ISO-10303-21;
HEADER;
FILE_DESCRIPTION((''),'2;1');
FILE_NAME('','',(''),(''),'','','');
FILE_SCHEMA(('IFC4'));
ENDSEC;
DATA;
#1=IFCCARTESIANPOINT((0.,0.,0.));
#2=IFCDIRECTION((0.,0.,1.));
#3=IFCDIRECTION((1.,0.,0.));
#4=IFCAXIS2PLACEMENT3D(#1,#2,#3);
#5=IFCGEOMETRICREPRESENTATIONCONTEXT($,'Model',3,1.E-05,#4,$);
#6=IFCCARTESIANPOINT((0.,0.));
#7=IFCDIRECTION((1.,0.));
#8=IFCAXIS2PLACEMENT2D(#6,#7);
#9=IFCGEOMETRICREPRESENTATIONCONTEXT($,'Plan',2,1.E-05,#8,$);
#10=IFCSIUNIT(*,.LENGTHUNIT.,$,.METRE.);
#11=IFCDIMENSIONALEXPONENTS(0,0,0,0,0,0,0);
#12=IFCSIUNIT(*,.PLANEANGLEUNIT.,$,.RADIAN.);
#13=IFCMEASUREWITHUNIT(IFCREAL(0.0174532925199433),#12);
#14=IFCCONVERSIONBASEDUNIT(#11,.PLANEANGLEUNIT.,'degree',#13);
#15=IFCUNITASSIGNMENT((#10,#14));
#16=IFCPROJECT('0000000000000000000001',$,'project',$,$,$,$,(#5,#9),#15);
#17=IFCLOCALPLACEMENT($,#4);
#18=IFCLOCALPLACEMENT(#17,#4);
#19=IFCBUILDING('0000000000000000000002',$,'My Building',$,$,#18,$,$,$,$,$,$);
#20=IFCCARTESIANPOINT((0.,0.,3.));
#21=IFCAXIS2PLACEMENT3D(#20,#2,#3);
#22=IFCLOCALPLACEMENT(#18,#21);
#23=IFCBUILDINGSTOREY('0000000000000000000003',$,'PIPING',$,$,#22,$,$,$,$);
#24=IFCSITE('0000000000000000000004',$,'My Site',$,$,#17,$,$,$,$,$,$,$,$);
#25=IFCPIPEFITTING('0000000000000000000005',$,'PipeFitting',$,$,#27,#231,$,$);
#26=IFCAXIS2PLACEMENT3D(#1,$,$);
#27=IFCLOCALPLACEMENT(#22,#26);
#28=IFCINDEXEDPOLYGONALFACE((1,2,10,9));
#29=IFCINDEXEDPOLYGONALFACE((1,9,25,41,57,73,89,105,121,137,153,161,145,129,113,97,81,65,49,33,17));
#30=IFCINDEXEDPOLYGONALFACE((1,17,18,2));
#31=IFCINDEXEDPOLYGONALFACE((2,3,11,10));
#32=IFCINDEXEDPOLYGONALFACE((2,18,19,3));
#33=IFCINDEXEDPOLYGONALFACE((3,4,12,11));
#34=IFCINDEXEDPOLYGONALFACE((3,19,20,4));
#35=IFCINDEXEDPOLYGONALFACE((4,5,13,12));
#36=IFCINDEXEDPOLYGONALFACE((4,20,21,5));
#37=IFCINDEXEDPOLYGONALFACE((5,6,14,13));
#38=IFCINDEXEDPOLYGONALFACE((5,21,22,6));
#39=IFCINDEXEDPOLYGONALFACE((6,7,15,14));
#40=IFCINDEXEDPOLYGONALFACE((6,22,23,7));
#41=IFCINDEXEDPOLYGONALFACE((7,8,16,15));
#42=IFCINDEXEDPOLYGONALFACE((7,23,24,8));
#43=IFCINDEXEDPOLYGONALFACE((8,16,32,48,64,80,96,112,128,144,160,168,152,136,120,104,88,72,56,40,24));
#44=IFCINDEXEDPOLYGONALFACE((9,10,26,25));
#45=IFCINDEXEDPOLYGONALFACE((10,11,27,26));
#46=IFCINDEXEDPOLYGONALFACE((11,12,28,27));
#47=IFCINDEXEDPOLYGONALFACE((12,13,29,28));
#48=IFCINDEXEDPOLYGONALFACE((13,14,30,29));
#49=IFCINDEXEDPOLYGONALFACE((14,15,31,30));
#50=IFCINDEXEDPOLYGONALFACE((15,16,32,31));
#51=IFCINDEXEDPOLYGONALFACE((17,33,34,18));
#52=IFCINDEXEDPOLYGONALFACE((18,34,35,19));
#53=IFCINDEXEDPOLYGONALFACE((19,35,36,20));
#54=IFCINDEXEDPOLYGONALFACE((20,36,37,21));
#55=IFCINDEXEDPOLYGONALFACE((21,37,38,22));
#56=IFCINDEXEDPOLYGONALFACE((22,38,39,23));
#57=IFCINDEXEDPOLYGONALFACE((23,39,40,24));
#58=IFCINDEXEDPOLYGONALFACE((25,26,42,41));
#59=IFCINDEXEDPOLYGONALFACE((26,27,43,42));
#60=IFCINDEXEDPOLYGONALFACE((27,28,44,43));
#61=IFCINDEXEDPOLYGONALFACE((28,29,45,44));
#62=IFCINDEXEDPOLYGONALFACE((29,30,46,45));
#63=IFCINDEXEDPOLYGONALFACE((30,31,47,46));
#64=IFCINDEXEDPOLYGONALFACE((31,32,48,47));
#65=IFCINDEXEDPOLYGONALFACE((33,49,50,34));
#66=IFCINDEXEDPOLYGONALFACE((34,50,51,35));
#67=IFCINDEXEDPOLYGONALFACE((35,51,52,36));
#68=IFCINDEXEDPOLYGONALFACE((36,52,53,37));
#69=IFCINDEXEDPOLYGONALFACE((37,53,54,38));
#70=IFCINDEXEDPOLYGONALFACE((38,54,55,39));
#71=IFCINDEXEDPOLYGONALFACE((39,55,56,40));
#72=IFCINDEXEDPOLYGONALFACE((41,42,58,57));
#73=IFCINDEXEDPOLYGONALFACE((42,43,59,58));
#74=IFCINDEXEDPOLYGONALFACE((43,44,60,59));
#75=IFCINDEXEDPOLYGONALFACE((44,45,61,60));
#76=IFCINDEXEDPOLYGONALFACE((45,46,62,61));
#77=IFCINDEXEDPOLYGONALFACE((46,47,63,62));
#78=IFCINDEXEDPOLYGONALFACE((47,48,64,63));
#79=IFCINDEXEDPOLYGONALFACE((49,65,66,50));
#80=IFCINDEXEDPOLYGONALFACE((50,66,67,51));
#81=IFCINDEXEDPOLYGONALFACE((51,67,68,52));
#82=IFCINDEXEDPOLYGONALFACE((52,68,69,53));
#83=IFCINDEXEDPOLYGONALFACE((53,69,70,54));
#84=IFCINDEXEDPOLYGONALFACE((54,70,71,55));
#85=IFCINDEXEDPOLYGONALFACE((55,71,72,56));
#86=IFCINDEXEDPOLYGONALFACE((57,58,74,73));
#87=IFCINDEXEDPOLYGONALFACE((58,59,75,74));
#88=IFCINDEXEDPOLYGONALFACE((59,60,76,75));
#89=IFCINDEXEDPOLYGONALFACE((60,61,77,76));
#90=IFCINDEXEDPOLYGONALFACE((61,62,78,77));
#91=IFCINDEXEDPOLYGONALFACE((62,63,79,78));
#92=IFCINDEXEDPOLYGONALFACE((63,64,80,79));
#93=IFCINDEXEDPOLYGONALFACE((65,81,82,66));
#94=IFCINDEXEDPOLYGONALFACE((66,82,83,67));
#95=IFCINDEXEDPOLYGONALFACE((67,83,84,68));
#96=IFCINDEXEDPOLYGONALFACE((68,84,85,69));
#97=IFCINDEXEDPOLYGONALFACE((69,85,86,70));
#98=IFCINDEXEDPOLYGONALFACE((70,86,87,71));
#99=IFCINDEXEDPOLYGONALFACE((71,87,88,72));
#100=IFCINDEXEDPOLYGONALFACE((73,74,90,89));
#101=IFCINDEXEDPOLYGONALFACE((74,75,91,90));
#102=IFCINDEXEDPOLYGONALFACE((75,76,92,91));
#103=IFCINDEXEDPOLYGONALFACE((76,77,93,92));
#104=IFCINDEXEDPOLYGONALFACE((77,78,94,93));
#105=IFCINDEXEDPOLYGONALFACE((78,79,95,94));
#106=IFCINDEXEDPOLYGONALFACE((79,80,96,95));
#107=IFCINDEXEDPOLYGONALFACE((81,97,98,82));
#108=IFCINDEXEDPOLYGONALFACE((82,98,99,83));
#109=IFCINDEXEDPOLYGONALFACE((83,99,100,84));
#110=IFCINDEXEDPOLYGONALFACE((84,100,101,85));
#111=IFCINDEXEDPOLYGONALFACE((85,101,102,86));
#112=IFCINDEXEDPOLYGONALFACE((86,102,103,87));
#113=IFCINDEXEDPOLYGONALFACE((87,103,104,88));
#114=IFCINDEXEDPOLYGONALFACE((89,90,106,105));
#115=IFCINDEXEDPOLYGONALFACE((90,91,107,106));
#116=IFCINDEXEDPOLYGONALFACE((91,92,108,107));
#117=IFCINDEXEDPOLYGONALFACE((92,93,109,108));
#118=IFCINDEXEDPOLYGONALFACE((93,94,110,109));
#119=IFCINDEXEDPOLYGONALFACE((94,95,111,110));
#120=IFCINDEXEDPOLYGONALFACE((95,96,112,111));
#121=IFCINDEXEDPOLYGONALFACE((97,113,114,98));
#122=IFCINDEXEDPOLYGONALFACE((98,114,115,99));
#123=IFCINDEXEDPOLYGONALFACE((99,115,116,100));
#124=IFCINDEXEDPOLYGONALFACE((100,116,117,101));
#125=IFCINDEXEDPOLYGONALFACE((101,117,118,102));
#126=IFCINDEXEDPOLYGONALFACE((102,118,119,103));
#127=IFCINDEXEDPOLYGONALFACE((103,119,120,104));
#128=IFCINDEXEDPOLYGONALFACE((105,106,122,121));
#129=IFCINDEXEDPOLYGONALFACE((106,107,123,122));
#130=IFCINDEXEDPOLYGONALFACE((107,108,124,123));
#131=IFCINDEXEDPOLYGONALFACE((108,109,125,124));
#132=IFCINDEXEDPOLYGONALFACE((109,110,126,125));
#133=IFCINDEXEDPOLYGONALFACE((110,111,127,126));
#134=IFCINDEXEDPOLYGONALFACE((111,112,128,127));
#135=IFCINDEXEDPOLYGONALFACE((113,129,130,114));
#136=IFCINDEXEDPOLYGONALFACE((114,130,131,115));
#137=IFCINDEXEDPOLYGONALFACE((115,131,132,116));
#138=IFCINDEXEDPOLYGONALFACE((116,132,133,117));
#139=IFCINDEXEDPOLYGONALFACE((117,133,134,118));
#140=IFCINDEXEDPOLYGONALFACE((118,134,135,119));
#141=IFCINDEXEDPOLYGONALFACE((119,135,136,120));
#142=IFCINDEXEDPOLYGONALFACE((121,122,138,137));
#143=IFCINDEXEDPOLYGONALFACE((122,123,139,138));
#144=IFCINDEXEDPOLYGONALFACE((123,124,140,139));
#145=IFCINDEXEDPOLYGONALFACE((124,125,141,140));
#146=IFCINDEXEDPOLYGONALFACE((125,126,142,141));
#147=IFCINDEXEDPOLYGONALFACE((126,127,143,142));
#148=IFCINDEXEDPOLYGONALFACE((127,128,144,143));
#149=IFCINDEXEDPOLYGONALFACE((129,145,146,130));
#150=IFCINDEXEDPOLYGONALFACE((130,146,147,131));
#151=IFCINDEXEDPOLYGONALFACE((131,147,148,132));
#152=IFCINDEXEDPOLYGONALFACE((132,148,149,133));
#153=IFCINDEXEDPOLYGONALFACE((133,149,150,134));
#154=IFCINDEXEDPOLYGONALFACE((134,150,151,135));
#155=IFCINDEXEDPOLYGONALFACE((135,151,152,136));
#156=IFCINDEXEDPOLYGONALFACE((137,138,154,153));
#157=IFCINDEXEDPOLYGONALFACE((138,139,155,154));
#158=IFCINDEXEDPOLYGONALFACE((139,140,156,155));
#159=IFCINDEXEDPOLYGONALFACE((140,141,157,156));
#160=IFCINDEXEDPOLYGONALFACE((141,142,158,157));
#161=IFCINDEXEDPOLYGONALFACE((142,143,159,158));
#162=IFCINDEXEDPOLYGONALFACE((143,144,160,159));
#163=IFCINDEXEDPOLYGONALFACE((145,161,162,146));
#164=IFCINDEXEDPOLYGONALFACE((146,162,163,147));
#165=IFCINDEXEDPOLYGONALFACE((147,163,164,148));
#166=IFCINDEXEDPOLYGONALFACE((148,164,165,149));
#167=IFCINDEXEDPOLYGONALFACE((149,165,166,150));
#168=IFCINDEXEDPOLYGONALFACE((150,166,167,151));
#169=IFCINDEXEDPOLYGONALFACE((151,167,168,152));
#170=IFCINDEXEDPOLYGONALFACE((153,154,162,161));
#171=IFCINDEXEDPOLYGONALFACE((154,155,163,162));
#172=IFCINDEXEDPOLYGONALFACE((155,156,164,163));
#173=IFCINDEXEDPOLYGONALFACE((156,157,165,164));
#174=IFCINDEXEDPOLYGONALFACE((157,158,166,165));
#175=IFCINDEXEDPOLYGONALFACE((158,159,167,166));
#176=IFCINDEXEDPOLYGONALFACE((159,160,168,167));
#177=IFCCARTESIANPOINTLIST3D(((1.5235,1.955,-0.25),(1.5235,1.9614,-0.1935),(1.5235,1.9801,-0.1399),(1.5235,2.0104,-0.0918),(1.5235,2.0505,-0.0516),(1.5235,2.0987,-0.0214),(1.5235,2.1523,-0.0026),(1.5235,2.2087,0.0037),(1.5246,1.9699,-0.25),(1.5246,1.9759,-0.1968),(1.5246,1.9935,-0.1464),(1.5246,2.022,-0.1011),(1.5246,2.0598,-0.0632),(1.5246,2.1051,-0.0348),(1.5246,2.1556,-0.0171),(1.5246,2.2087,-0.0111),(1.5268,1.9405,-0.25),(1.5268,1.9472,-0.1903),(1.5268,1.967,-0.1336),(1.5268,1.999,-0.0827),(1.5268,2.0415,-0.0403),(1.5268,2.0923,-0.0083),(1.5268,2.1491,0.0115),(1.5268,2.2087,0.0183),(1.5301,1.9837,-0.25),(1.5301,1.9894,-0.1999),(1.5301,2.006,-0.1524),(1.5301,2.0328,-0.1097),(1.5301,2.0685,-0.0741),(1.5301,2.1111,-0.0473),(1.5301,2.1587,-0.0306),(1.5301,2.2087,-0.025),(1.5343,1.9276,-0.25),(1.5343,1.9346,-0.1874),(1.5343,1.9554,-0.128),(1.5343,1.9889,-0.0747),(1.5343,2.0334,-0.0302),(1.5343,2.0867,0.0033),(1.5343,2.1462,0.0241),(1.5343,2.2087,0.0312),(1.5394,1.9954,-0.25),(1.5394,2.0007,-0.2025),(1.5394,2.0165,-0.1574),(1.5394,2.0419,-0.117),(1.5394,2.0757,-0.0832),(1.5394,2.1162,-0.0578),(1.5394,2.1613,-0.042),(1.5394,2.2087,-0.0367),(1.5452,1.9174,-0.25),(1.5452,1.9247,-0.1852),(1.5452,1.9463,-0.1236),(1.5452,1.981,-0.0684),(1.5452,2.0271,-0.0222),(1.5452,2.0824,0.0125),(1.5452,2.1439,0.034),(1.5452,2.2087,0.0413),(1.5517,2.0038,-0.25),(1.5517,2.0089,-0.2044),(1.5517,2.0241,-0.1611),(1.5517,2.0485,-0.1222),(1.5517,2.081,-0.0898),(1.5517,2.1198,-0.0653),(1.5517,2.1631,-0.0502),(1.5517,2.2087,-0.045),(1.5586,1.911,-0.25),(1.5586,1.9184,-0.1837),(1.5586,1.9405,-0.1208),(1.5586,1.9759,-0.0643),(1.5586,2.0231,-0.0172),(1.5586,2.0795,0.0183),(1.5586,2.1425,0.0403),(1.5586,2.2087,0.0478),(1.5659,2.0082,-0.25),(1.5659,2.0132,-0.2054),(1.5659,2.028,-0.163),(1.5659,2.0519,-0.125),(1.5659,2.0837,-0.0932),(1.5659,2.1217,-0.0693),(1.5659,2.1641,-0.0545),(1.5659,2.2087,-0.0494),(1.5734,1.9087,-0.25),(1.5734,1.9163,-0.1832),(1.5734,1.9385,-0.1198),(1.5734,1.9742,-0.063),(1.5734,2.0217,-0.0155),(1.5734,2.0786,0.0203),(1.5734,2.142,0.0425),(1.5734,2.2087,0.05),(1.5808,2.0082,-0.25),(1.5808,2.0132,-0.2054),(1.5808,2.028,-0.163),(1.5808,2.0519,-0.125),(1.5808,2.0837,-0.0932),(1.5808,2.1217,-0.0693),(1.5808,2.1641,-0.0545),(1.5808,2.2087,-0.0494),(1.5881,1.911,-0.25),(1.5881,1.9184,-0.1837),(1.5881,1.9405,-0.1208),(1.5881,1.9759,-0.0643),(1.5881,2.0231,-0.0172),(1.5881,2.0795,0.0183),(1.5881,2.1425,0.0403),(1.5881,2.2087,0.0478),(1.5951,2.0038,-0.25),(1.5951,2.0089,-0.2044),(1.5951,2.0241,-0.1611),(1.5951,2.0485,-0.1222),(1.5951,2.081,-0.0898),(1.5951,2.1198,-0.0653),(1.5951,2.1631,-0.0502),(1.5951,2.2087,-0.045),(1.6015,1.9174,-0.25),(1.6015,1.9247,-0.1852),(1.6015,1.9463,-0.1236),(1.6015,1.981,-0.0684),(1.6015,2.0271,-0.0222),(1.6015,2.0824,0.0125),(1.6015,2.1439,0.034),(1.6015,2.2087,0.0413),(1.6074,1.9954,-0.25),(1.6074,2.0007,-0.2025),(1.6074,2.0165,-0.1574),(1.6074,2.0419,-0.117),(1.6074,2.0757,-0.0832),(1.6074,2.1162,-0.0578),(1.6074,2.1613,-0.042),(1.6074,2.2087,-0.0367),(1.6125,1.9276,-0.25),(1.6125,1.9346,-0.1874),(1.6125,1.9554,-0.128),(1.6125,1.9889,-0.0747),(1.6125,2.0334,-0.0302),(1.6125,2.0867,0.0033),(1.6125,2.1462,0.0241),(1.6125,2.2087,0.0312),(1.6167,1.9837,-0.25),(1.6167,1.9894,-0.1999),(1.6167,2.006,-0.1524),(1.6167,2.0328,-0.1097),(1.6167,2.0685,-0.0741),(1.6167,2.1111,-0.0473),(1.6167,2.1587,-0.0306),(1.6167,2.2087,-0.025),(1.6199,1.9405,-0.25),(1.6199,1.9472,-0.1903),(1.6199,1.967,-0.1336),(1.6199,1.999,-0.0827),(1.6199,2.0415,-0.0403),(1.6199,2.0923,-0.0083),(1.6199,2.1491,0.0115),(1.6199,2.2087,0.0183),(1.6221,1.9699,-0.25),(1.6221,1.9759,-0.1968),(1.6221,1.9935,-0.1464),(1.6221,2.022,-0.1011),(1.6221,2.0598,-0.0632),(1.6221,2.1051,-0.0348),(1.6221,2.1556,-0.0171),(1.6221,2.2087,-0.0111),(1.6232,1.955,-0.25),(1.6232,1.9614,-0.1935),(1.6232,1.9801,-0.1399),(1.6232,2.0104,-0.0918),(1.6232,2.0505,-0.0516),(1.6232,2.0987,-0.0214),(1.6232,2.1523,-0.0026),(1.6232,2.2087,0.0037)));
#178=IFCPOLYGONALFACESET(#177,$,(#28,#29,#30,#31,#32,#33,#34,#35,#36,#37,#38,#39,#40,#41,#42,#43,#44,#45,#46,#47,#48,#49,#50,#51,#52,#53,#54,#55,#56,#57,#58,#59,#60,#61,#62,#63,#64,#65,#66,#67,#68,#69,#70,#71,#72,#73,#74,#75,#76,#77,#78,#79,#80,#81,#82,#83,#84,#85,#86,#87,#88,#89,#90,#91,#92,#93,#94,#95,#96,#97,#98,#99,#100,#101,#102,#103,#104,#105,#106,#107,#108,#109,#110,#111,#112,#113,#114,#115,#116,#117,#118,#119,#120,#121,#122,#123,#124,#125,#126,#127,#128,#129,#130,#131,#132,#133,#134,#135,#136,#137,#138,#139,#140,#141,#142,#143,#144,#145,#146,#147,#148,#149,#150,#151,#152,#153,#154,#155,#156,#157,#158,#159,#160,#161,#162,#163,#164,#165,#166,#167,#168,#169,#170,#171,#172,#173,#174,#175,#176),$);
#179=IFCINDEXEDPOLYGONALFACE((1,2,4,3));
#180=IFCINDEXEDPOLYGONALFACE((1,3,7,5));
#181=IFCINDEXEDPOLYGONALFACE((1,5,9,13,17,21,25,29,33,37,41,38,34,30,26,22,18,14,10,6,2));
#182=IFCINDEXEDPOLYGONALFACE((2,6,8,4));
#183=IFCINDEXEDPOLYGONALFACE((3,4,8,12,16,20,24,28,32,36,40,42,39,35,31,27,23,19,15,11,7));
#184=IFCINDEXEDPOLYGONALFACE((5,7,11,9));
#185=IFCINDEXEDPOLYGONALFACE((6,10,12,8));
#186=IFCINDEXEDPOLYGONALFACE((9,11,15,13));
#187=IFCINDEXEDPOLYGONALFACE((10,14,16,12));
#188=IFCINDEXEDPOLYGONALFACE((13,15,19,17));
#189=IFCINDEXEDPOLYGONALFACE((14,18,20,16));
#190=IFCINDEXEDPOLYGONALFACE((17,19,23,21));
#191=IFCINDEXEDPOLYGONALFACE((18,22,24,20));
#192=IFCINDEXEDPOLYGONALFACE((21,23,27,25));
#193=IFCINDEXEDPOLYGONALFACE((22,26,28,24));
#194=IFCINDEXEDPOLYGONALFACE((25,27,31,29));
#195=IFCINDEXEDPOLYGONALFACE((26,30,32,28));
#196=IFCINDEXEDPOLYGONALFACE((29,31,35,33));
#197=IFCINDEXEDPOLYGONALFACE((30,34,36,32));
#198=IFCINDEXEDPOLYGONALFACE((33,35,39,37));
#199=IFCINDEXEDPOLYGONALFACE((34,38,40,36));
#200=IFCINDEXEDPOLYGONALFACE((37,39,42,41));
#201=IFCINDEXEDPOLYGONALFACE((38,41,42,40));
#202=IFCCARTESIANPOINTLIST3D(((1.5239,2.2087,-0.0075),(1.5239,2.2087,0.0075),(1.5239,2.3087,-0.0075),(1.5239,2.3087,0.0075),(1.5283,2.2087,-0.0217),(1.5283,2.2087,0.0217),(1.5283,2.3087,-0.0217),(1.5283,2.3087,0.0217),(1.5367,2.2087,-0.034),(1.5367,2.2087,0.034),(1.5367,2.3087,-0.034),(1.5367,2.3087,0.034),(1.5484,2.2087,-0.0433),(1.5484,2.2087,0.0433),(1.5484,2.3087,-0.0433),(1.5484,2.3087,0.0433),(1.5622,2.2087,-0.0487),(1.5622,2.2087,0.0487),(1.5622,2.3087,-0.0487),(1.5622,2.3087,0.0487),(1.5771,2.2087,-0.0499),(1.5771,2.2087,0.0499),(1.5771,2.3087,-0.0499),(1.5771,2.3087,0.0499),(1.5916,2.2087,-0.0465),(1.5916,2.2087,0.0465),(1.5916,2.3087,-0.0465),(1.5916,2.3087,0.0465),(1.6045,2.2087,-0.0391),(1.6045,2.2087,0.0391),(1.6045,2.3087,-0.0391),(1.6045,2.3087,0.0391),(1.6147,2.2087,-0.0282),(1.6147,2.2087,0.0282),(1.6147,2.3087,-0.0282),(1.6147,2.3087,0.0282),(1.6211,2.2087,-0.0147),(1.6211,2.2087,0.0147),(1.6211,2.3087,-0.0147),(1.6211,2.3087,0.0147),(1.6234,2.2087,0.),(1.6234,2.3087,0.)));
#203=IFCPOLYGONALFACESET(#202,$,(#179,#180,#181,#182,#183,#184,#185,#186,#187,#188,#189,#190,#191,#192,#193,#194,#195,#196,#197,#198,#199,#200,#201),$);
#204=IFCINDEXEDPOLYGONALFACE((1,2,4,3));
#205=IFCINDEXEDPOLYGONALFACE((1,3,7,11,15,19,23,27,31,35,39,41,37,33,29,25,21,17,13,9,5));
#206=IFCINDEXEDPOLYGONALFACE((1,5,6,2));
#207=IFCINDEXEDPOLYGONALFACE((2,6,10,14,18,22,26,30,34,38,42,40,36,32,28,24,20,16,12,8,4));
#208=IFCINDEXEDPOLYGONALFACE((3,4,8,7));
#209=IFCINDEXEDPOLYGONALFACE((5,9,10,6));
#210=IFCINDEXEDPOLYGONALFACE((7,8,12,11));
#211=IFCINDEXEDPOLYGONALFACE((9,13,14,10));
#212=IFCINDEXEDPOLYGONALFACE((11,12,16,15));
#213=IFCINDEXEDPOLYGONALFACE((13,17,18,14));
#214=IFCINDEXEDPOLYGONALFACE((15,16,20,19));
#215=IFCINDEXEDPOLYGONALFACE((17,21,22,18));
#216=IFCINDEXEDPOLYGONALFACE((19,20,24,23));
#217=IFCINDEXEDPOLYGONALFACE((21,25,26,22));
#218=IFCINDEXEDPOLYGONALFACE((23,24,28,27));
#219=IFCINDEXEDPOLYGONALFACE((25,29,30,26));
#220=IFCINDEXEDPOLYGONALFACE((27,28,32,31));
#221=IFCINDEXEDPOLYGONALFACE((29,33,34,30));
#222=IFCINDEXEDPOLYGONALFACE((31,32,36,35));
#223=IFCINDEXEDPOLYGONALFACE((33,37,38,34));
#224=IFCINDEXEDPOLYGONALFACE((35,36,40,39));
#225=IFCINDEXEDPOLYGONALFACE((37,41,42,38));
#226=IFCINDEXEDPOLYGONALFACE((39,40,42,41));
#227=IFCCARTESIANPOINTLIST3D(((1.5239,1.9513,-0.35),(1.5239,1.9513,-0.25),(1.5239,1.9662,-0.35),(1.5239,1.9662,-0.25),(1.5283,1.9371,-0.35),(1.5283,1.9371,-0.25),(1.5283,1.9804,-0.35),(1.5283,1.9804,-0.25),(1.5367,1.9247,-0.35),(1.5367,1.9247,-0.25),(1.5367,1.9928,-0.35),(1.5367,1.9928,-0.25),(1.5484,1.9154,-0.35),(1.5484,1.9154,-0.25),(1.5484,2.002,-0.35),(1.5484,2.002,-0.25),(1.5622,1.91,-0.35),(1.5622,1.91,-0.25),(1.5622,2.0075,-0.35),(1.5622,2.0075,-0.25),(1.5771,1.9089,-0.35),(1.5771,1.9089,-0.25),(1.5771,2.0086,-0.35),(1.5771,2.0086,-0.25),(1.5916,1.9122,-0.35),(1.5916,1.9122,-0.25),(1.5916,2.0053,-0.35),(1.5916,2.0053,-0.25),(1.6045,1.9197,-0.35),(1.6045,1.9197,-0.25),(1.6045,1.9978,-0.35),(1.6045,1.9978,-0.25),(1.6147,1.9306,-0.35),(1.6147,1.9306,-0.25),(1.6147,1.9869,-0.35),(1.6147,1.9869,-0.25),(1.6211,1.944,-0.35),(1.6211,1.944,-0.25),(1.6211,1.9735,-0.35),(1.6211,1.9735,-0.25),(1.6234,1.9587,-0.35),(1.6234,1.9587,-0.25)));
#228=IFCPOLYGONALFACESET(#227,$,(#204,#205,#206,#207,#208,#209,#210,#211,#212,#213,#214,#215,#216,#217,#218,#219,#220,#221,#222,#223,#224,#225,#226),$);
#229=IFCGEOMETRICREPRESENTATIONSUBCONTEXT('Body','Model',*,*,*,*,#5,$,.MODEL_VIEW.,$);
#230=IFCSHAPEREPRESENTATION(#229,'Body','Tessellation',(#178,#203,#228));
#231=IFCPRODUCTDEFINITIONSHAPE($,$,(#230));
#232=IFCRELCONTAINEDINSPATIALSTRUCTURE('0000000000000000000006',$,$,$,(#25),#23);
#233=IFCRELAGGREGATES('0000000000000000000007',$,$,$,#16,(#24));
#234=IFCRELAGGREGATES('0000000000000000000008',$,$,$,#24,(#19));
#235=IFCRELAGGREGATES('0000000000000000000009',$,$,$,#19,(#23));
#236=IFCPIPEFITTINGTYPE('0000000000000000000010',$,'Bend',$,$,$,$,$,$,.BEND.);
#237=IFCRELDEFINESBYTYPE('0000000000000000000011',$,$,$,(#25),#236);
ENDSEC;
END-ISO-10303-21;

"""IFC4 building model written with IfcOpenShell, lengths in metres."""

from ifc_helpers import new_model, entity, si_unit, converted_unit, frame, origin_with_axes, origin_2d_with_axis, place, context, subcontext, project, spatial, circle, extrude, source, transform, mapped, type_object, type_shapes, element, save


model = new_model("IFC4")

# Units and contexts
model_context = context("Model", 3, precision=1e-05, world=origin_with_axes())
plan_context = context("Plan", 2, precision=1e-05, world=origin_2d_with_axis())
body_context = subcontext(model_context, "Body", "Model", "MODEL_VIEW")
ifc_project = project(units=[si_unit("LENGTHUNIT", "METRE"), converted_unit("PLANEANGLEUNIT", "degree", entity("IfcReal", 0.0174532925199433), si_unit("PLANEANGLEUNIT", "RADIAN"), dimensions=[0, 0, 0, 0, 0, 0, 0])], contexts=[model_context, plan_context])

# Site, building, storey
site_placement = place(None, origin_with_axes())
site = spatial("IfcSite", under=ifc_project, at=site_placement, Name="My Site")
building_placement = place(site_placement, origin_with_axes())
building = spatial("IfcBuilding", under=site, at=building_placement, Name="My Building")
storey_placement = place(building_placement, frame((0.0, 0.0, 3.0), z_axis=(0.0, 0.0, 1.0), x_axis=(1.0, 0.0, 0.0)))
storey = spatial("IfcBuildingStorey", under=building, at=storey_placement, Name="PIPING")

# Pipe fitting
pipe_fitting_type = type_object("IfcPipeFittingType", Name="Bend", PredefinedType="BEND")
shared_shape = source(origin_with_axes(), body_context, "Body", "SolidModel", [
    entity("IfcSweptDiskSolid", entity("IfcIndexedPolyCurve", entity("IfcCartesianPointList3D", [[0.0, 0.0, 0.1], [0.0, -0.0732, 0.2768], [0.0, -0.25, 0.35]]), [entity("IfcArcIndex", [1, 2, 3])]), 0.05),
    extrude(circle(Radius=0.05), origin_with_axes(), (0.0, 0.0, 1.0), 0.1),
    extrude(circle(Radius=0.05), frame((0.0, -0.25, 0.35), z_axis=(0.0, -1.0, 0.0), x_axis=(1.0, 0.0, 0.0)), (0.0, 0.0, 1.0), 0.1),
])
type_shapes(pipe_fitting_type, [shared_shape])
for number, where, z_axis, x_axis, name in (
    (1, (1.5734, 2.3087, 0.0), (0.0, -1.0, 0.0), (1.0, 0.0, 0.0), "PipeFitting"),
):
    element("IfcPipeFitting", number, at=place(storey_placement, frame(where, z_axis=z_axis, x_axis=x_axis)), inside=storey, type_object=pipe_fitting_type, Name=name, context=body_context, shape_type="MappedRepresentation", body=[
        mapped(shared_shape, transform((0.0, 0.0, 0.0), x_axis=(1.0, 0.0, 0.0), y_axis=(0.0, 1.0, 0.0), z_axis=(0.0, 0.0, 1.0), scale=1.0)),
    ])

save(model, "model.ifc")
